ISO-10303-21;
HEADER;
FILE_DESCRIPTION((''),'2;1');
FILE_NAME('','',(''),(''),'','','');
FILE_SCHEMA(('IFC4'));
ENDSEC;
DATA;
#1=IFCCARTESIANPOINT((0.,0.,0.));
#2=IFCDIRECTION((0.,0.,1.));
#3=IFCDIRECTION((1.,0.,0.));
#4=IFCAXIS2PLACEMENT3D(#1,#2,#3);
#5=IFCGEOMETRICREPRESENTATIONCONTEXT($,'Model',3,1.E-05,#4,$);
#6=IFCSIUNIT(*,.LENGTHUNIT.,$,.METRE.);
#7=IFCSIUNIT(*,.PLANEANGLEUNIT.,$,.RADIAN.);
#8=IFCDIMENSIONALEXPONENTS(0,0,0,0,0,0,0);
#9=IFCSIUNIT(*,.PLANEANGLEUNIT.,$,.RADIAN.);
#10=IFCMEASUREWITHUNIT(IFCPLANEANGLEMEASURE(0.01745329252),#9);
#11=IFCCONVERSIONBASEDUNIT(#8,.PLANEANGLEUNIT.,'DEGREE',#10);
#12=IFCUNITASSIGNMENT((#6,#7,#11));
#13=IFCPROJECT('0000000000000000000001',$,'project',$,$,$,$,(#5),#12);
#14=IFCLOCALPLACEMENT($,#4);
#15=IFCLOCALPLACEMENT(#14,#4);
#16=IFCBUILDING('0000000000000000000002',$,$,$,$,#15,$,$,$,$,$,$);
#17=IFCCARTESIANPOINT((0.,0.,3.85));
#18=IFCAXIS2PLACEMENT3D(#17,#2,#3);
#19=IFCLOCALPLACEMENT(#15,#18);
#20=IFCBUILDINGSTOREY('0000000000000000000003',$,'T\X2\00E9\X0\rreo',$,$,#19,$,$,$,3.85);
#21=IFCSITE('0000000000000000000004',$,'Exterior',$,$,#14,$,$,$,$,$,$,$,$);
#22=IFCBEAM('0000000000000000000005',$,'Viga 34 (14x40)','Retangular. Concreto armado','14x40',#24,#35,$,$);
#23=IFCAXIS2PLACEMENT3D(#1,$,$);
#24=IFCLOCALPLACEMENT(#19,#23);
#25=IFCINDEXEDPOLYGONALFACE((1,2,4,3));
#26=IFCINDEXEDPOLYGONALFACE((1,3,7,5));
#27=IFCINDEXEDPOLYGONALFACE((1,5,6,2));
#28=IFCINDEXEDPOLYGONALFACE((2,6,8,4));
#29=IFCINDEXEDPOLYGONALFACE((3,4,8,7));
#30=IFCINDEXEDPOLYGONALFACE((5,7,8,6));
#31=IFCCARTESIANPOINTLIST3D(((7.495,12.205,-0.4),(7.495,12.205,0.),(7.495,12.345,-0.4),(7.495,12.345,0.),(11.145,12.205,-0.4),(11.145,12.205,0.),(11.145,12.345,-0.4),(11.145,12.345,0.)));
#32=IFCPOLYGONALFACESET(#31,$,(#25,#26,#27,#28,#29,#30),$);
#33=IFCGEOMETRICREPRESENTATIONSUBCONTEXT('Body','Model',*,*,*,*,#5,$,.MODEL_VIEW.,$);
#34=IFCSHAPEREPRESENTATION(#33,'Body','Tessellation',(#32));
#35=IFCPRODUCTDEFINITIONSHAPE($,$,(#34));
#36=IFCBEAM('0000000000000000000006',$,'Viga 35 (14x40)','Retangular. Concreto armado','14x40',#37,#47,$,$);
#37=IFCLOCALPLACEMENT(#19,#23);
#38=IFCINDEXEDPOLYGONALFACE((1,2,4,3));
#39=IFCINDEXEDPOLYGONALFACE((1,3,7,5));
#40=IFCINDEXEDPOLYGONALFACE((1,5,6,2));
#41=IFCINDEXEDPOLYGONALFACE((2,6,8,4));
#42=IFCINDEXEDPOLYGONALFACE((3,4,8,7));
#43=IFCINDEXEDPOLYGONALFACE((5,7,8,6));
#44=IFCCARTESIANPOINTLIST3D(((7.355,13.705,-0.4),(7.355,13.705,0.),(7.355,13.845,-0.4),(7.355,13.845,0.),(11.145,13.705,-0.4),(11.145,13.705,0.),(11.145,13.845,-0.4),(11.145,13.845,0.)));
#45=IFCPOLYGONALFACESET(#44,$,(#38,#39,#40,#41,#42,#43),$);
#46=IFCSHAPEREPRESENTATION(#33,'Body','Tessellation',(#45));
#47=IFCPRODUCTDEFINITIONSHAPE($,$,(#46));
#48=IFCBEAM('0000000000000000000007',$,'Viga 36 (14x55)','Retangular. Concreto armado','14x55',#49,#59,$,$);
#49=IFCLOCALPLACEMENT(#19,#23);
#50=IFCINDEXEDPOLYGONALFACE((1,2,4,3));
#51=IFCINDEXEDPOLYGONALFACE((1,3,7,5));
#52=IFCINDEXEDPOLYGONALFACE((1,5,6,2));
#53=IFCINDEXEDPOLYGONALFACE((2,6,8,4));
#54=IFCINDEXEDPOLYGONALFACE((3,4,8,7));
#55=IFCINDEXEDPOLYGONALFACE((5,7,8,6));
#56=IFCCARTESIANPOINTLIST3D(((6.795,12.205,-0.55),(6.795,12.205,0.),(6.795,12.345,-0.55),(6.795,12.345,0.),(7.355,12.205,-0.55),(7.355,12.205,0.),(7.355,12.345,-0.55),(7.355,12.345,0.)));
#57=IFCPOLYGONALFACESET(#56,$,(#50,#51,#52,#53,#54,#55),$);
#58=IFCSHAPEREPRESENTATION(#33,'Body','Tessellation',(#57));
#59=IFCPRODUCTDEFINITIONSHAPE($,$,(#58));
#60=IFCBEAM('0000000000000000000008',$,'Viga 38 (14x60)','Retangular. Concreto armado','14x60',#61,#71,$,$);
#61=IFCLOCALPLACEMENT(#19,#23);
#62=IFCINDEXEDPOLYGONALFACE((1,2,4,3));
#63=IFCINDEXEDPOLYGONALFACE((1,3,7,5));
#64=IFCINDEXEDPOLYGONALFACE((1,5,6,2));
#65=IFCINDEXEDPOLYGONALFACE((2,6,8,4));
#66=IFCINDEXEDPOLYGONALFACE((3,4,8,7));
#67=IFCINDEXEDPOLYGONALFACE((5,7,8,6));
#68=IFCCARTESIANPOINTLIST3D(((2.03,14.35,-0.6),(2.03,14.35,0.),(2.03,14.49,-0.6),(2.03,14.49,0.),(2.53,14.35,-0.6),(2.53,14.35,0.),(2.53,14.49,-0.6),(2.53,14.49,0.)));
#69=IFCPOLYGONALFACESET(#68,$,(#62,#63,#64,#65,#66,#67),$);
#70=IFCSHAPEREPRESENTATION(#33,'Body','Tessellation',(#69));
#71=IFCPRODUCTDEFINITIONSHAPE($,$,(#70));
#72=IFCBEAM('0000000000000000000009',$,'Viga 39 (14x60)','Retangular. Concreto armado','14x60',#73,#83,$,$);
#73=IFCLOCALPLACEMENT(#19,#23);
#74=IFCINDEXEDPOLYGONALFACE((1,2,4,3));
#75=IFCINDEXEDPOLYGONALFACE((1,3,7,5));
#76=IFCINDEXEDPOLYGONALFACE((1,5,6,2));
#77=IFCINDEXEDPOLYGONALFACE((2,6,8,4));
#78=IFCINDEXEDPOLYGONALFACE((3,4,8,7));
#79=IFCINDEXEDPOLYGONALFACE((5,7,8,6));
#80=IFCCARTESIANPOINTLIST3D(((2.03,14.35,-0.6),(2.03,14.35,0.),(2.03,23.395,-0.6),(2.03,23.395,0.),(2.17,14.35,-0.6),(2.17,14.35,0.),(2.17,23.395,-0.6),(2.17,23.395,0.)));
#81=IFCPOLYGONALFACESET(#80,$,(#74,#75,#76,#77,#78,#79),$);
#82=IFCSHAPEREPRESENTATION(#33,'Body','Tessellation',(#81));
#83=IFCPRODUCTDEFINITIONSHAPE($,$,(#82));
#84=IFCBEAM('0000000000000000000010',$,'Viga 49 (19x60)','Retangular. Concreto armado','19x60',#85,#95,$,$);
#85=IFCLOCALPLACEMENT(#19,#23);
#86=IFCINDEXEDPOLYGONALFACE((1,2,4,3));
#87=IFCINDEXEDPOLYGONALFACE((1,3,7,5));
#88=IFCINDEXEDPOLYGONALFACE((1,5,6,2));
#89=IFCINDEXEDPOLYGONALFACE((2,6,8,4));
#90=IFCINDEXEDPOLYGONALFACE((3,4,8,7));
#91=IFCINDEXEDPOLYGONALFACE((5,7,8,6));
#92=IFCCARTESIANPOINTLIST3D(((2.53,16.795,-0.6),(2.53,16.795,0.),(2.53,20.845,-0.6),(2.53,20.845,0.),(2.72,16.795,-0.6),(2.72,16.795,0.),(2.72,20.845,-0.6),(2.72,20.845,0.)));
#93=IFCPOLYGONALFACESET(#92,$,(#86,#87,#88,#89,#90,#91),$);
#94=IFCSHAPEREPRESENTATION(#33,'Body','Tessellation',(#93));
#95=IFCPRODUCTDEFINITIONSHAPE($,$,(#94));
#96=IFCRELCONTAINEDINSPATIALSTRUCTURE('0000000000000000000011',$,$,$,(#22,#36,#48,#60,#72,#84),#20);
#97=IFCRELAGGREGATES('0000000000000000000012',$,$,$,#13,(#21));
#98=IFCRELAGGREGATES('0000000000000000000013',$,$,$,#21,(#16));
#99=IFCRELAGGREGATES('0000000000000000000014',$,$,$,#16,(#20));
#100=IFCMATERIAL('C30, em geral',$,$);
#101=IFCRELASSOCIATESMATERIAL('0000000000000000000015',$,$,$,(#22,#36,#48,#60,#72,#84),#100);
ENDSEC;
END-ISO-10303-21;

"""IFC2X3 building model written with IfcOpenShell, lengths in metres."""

from ifc_helpers import new_model, entity, si_unit, converted_unit, frame, frame_2d, origin_with_axes, place, context, subcontext, project, spatial, rectangle, extrude, material, element, save


model = new_model("IFC2X3")

# Units and contexts
model_context = context("Model", 3, precision=1e-05, world=origin_with_axes())
body_context = subcontext(model_context, "Body", "Model", "MODEL_VIEW")
ifc_project = project(units=[si_unit("LENGTHUNIT", "METRE"), si_unit("PLANEANGLEUNIT", "RADIAN"), converted_unit("PLANEANGLEUNIT", "DEGREE", entity("IfcPlaneAngleMeasure", 0.01745329252), si_unit("PLANEANGLEUNIT", "RADIAN"), dimensions=[0, 0, 0, 0, 0, 0, 0])], contexts=[model_context])

# Site, building, storey
site_placement = place(None, origin_with_axes())
site = spatial("IfcSite", under=ifc_project, at=site_placement, Name="Exterior")
building_placement = place(site_placement, origin_with_axes())
building = spatial("IfcBuilding", under=site, at=building_placement)
storey_placement = place(building_placement, frame((0.0, 0.0, 3.85), z_axis=(0.0, 0.0, 1.0), x_axis=(1.0, 0.0, 0.0)))
storey = spatial("IfcBuildingStorey", under=building, at=storey_placement, Name="Térreo", Elevation=3.85)

# Beams
ifc_material_1 = material(Name="C30, em geral")
beam_1_placement = place(storey_placement, frame((7.495, 12.275, 0.0), z_axis=(1.0, 0.0, 0.0), x_axis=(0.0, 1.0, 0.0)))
element("IfcBeam", 1, at=beam_1_placement, inside=storey, material=ifc_material_1, Name="Viga 34 (14x40)", Description="Retangular. Concreto armado", ObjectType="14x40", context=body_context, shape_type="SweptSolid", body=[
    extrude(rectangle(XDim=0.14, YDim=0.4, at=frame_2d((0.0, -0.2), x_axis=(1.0, 0.0))), origin_with_axes(), (0.0, 0.0, 1.0), 3.65),
])
beam_2_placement = place(storey_placement, frame((11.145, 13.775, 0.0), z_axis=(-1.0, 0.0, 0.0), x_axis=(0.0, -1.0, 0.0)))
element("IfcBeam", 2, at=beam_2_placement, inside=storey, material=ifc_material_1, Name="Viga 35 (14x40)", Description="Retangular. Concreto armado", ObjectType="14x40", context=body_context, shape_type="SweptSolid", body=[
    extrude(rectangle(XDim=0.14, YDim=0.4, at=frame_2d((0.0, -0.2), x_axis=(1.0, 0.0))), origin_with_axes(), (0.0, 0.0, 1.0), 3.79),
])
beam_3_placement = place(storey_placement, frame((6.795, 12.275, 0.0), z_axis=(1.0, 0.0, 0.0), x_axis=(0.0, 1.0, 0.0)))
element("IfcBeam", 3, at=beam_3_placement, inside=storey, material=ifc_material_1, Name="Viga 36 (14x55)", Description="Retangular. Concreto armado", ObjectType="14x55", context=body_context, shape_type="SweptSolid", body=[
    extrude(rectangle(XDim=0.14, YDim=0.55, at=frame_2d((0.0, -0.275), x_axis=(1.0, 0.0))), origin_with_axes(), (0.0, 0.0, 1.0), 0.56),
])
beam_4_placement = place(storey_placement, frame((2.53, 14.42, 0.0), z_axis=(-1.0, 0.0, 0.0), x_axis=(0.0, -1.0, 0.0)))
element("IfcBeam", 4, at=beam_4_placement, inside=storey, material=ifc_material_1, Name="Viga 38 (14x60)", Description="Retangular. Concreto armado", ObjectType="14x60", context=body_context, shape_type="SweptSolid", body=[
    extrude(rectangle(XDim=0.14, YDim=0.6, at=frame_2d((0.0, -0.3), x_axis=(1.0, 0.0))), origin_with_axes(), (0.0, 0.0, 1.0), 0.5),
])
beam_5_placement = place(storey_placement, frame((2.1, 14.35, 0.0), z_axis=(0.0, 1.0, 0.0), x_axis=(-1.0, 0.0, 0.0)))
element("IfcBeam", 5, at=beam_5_placement, inside=storey, material=ifc_material_1, Name="Viga 39 (14x60)", Description="Retangular. Concreto armado", ObjectType="14x60", context=body_context, shape_type="SweptSolid", body=[
    extrude(rectangle(XDim=0.14, YDim=0.6, at=frame_2d((0.0, -0.3), x_axis=(1.0, 0.0))), origin_with_axes(), (0.0, 0.0, 1.0), 9.045),
])
beam_6_placement = place(storey_placement, frame((2.625, 16.795, 0.0), z_axis=(0.0, 1.0, 0.0), x_axis=(-1.0, 0.0, 0.0)))
element("IfcBeam", 6, at=beam_6_placement, inside=storey, material=ifc_material_1, Name="Viga 49 (19x60)", Description="Retangular. Concreto armado", ObjectType="19x60", context=body_context, shape_type="SweptSolid", body=[
    extrude(rectangle(XDim=0.19, YDim=0.6, at=frame_2d((0.0, -0.3), x_axis=(1.0, 0.0))), origin_with_axes(), (0.0, 0.0, 1.0), 4.05),
])

save(model, "model.ifc")
